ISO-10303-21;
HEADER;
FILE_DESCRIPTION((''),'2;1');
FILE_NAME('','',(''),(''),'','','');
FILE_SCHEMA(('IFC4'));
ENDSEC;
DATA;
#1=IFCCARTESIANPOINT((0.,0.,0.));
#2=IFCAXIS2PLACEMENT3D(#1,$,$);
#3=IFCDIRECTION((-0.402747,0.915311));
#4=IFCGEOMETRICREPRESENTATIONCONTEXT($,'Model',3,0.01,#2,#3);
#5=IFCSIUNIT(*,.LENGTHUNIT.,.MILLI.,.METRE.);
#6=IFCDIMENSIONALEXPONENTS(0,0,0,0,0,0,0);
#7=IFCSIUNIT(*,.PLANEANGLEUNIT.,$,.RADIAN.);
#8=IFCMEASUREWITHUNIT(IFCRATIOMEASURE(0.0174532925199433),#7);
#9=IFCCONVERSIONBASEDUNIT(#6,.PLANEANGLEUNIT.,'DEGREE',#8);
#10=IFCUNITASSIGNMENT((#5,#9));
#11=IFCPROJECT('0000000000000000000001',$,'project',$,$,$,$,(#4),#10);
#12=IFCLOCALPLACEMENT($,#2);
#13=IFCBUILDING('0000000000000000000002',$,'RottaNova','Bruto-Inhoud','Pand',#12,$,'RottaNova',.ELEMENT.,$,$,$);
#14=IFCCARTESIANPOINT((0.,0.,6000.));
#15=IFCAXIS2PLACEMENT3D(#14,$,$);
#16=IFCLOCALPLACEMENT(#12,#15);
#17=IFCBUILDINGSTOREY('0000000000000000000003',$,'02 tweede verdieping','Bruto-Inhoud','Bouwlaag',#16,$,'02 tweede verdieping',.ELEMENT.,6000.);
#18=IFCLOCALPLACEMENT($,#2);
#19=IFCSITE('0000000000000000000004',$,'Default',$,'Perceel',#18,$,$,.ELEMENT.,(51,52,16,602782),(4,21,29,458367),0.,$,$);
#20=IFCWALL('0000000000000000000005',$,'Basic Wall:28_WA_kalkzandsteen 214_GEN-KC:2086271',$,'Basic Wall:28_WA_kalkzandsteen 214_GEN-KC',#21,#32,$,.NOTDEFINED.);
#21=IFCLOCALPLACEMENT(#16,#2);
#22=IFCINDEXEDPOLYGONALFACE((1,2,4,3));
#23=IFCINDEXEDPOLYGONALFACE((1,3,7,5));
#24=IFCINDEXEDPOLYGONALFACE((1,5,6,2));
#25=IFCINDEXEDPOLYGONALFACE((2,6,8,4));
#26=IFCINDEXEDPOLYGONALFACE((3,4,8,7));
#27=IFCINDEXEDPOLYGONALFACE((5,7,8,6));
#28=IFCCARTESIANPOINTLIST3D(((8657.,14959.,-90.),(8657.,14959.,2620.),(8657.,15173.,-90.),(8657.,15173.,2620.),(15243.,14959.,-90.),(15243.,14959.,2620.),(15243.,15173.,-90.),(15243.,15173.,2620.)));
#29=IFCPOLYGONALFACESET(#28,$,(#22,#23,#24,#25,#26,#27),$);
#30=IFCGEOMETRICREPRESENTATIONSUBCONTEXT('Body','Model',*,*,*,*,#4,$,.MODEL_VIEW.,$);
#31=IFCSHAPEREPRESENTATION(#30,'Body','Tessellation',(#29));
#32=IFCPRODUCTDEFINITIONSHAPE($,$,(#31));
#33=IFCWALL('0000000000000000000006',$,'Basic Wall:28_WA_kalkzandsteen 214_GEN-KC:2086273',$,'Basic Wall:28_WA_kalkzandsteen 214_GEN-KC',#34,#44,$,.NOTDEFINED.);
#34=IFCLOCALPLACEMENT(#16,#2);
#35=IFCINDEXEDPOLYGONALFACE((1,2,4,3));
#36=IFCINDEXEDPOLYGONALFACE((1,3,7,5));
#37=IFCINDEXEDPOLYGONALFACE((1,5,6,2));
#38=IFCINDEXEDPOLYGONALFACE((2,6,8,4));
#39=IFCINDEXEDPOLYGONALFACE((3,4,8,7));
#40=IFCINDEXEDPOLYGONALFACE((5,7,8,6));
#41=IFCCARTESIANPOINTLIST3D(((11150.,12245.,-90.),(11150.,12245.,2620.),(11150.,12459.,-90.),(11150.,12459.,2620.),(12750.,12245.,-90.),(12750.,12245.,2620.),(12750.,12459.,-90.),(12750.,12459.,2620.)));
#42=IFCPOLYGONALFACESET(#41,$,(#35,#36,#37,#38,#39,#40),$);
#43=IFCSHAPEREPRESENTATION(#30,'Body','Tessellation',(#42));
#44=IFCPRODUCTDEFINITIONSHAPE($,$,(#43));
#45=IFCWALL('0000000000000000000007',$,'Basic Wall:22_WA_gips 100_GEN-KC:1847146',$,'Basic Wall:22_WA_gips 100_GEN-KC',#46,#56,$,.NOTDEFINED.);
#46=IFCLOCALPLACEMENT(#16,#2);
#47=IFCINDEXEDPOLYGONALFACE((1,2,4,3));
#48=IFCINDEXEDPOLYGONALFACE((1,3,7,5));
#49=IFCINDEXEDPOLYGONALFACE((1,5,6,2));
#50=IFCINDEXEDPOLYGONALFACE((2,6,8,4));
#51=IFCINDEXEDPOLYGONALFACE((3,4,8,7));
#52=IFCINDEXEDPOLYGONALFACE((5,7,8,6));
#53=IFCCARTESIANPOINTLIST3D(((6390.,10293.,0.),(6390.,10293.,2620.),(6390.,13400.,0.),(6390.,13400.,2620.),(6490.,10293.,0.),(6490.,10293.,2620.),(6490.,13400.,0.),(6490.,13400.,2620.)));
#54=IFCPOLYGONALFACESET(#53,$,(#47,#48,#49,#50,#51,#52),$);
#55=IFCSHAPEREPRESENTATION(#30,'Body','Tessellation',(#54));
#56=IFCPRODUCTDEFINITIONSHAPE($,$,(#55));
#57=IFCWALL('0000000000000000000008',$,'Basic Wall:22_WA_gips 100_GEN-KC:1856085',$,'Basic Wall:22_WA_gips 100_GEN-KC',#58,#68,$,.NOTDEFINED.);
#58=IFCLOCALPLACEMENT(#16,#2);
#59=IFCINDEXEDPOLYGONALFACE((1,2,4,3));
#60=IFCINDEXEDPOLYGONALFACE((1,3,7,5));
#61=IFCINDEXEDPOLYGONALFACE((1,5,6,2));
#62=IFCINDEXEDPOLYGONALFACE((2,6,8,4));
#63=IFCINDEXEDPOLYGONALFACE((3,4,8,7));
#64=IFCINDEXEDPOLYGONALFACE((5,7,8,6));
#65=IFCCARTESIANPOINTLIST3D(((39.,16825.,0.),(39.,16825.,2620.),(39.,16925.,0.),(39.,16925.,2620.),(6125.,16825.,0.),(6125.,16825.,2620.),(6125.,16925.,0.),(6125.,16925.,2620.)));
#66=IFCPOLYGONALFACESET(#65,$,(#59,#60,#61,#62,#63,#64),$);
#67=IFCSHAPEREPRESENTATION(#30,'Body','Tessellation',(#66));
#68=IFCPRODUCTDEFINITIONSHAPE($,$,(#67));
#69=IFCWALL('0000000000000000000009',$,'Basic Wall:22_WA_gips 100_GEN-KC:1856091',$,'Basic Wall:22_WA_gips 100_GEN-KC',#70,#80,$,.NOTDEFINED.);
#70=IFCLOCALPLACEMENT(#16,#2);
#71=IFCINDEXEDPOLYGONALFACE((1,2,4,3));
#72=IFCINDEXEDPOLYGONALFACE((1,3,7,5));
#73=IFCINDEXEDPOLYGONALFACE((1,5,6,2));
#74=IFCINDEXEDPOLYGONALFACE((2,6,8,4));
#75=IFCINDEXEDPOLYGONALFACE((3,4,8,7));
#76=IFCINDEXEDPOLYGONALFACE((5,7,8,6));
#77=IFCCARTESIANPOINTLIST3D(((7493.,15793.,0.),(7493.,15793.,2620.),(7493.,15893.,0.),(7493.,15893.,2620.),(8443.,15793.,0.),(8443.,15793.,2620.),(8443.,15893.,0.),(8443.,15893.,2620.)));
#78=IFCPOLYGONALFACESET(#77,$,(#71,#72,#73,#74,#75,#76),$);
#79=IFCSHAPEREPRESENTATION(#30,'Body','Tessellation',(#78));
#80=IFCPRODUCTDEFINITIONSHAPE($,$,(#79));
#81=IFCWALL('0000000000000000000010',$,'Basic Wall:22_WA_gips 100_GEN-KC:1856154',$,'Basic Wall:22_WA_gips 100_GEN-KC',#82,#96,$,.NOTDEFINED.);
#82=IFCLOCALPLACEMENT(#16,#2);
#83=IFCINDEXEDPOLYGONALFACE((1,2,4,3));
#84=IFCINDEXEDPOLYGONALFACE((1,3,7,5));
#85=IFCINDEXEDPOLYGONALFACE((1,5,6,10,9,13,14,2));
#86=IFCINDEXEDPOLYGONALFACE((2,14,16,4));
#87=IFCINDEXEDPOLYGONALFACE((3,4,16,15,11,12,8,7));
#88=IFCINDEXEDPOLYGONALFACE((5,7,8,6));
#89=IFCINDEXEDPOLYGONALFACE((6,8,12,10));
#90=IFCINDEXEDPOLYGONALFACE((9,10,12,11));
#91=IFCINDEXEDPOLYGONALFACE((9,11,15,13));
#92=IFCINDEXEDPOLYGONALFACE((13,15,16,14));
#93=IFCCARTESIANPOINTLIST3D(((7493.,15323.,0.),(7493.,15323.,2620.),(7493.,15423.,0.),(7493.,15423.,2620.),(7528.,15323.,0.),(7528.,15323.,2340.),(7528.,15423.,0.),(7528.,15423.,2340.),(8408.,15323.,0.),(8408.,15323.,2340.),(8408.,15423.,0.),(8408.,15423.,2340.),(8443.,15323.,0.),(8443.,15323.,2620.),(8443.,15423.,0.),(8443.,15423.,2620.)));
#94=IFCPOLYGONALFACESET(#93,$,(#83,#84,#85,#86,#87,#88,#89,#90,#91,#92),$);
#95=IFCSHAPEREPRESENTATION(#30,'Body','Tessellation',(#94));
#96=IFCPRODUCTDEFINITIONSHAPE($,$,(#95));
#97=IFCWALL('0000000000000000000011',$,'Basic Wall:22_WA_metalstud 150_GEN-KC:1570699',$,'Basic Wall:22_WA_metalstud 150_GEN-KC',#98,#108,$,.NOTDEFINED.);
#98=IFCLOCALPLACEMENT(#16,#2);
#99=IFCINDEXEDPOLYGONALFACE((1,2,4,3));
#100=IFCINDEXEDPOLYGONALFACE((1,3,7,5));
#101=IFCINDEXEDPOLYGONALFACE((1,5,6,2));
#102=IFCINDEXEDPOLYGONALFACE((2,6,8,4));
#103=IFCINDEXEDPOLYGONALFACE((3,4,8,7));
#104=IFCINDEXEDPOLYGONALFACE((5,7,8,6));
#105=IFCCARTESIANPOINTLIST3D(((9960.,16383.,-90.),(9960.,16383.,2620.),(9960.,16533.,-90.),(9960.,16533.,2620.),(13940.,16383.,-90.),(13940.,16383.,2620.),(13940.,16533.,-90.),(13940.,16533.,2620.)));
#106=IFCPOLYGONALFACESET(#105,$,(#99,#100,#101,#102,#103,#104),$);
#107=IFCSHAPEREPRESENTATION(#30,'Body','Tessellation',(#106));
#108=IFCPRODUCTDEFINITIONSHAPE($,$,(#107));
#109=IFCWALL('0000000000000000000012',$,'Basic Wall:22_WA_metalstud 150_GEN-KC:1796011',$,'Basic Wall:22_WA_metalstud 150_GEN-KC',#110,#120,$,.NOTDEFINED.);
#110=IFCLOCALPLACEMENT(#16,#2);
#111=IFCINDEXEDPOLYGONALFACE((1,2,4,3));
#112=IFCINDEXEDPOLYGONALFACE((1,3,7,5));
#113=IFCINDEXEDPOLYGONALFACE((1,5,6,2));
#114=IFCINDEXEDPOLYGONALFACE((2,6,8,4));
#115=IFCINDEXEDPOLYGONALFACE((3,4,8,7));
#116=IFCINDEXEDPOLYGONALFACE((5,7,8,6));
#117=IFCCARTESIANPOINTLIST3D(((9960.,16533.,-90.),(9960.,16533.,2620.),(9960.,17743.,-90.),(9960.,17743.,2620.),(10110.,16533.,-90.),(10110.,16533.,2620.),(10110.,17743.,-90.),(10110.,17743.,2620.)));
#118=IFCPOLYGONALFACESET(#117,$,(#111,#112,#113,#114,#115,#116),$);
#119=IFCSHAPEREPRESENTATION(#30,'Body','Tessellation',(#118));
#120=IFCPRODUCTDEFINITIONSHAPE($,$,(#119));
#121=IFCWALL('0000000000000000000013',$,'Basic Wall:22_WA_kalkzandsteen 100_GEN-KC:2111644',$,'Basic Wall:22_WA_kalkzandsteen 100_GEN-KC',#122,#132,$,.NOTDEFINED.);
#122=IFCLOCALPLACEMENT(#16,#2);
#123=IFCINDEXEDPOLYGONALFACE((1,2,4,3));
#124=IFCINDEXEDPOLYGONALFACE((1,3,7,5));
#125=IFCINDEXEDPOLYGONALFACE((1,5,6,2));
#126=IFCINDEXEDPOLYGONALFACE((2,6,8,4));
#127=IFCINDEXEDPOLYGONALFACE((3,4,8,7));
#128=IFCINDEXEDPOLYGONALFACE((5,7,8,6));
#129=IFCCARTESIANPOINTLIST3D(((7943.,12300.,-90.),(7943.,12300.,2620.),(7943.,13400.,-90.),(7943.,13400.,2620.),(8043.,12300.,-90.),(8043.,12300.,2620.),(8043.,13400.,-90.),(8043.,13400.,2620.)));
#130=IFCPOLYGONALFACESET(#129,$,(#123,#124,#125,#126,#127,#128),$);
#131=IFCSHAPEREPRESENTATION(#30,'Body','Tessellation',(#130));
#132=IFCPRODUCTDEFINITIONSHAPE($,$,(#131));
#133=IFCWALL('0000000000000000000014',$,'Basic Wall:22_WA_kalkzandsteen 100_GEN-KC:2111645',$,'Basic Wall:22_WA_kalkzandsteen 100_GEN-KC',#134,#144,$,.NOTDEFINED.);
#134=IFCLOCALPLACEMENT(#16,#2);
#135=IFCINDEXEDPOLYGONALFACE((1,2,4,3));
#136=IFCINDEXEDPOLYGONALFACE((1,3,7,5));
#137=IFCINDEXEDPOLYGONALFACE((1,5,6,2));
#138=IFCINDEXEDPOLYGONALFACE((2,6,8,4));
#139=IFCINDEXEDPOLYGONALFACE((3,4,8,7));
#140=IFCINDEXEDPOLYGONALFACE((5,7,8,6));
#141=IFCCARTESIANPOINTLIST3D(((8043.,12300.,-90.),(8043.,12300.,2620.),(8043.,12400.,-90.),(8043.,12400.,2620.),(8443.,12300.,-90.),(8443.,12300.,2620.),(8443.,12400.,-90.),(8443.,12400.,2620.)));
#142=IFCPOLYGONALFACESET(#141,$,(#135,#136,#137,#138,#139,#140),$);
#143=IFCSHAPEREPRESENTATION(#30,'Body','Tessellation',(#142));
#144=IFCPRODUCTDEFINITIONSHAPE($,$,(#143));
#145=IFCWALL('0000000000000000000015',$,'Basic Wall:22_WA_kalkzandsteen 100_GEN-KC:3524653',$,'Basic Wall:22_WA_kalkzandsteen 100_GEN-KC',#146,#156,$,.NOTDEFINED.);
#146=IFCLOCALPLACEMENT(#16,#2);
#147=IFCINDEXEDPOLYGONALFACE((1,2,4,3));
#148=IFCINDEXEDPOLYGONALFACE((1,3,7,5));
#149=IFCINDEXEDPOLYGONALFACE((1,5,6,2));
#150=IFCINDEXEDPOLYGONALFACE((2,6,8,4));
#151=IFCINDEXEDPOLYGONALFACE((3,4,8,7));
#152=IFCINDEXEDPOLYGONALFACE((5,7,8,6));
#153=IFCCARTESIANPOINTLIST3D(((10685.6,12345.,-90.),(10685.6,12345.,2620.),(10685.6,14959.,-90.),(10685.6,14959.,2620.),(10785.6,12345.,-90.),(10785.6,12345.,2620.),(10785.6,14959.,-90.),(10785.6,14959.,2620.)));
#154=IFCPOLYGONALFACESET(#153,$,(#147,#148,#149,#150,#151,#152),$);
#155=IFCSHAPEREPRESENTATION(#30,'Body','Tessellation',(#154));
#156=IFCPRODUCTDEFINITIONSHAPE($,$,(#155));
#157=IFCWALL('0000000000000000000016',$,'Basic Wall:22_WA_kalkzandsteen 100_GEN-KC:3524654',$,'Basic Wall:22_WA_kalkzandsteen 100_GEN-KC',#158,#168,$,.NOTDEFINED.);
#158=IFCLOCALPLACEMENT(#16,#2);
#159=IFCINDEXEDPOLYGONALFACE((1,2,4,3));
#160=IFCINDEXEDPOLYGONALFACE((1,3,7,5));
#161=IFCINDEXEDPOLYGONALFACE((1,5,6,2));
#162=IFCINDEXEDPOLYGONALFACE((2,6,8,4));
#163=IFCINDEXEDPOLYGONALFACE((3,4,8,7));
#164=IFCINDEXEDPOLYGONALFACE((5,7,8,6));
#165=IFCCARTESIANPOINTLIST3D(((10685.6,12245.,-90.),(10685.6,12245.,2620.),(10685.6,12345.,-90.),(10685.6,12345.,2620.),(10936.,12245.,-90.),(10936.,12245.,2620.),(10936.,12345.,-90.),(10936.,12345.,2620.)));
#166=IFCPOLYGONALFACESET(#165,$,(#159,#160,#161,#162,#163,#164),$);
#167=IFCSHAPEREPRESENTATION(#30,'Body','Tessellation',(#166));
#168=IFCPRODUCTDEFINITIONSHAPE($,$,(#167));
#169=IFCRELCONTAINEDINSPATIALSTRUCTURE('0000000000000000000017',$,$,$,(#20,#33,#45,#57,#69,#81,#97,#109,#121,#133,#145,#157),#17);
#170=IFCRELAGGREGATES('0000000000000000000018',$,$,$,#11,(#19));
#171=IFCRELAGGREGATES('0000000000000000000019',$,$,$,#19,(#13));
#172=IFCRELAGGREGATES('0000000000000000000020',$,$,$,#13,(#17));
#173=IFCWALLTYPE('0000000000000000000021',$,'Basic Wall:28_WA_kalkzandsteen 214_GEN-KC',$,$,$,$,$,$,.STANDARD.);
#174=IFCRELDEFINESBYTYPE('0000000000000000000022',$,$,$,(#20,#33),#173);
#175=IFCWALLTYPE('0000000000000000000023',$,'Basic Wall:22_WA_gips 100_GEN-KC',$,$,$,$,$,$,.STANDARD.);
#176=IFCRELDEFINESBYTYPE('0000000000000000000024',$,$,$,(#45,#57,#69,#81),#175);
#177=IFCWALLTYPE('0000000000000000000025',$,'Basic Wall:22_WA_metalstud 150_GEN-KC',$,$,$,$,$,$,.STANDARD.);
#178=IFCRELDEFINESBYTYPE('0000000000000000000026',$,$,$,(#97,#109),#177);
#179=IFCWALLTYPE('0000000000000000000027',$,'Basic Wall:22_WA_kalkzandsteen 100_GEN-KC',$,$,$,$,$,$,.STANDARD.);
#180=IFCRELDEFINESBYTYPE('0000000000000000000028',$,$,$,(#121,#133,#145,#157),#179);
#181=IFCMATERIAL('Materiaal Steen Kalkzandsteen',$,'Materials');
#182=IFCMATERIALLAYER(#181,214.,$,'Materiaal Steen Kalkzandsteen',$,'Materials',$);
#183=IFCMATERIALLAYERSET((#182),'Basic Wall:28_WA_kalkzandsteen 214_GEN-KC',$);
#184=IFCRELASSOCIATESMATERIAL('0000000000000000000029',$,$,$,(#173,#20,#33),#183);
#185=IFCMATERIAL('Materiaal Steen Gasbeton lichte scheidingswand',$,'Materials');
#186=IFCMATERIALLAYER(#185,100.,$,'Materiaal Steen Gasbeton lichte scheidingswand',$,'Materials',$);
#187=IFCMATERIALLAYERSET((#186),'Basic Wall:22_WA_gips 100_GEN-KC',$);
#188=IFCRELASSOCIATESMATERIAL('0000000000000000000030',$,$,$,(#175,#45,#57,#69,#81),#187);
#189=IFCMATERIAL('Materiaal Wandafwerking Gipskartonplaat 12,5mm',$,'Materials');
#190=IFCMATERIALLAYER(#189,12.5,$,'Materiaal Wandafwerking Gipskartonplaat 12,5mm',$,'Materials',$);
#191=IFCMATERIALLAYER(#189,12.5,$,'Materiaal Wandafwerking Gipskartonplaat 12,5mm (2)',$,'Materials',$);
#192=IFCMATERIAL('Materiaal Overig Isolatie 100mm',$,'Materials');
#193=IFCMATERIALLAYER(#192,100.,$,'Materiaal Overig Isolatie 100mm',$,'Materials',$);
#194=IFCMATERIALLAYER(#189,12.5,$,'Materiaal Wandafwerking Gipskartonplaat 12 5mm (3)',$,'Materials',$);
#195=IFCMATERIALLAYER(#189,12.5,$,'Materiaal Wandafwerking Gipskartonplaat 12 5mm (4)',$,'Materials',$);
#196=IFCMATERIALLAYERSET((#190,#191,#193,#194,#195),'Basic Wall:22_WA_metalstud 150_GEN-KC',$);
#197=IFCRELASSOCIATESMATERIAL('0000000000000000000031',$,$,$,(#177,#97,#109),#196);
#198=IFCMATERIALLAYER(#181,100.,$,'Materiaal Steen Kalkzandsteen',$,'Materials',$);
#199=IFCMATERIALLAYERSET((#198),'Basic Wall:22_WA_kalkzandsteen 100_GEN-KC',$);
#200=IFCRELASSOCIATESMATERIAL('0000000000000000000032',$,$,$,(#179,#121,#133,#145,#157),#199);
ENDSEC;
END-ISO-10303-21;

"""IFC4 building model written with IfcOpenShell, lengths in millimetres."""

from ifc_helpers import new_model, entity, si_unit, converted_unit, direction, frame, frame_2d, origin, place, context, subcontext, project, spatial, rectangle, extrude, material, layer, layer_set, type_object, element, save


model = new_model("IFC4")

# Units and contexts
model_context = context("Model", 3, precision=0.01, world=origin(), true_north=direction((-0.402747, 0.915311)))
body_context = subcontext(model_context, "Body", "Model", "MODEL_VIEW")
ifc_project = project(units=[si_unit("LENGTHUNIT", "METRE", prefix="MILLI"), converted_unit("PLANEANGLEUNIT", "DEGREE", entity("IfcRatioMeasure", 0.0174532925199433), si_unit("PLANEANGLEUNIT", "RADIAN"), dimensions=[0, 0, 0, 0, 0, 0, 0])], contexts=[model_context])

# Site, building, storey
site_placement = place(None, origin())
site = spatial("IfcSite", under=ifc_project, at=site_placement, Name="Default", ObjectType="Perceel", CompositionType="ELEMENT", RefLatitude=(51, 52, 16, 602782), RefLongitude=(4, 21, 29, 458367), RefElevation=0.0)
building_placement = place(None, origin())
building = spatial("IfcBuilding", under=site, at=building_placement, Name="RottaNova", Description="Bruto-Inhoud", ObjectType="Pand", LongName="RottaNova", CompositionType="ELEMENT")
storey_placement = place(building_placement, frame((0.0, 0.0, 6000.0)))
storey = spatial("IfcBuildingStorey", under=building, at=storey_placement, Name="02 tweede verdieping", Description="Bruto-Inhoud", ObjectType="Bouwlaag", LongName="02 tweede verdieping", CompositionType="ELEMENT", Elevation=6000.0)

# Walls
ifc_material_1 = material(Name="Materiaal Steen Kalkzandsteen", Category="Materials")
ifc_layer_1 = layer(ifc_material_1, 214.0, Name="Materiaal Steen Kalkzandsteen", Category="Materials")
ifc_layer_set_1 = layer_set([ifc_layer_1], Name="Basic Wall:28_WA_kalkzandsteen 214_GEN-KC")
wall_type_1 = type_object("IfcWallType", Name="Basic Wall:28_WA_kalkzandsteen 214_GEN-KC", PredefinedType="STANDARD", material=ifc_layer_set_1)
wall_1_placement = place(storey_placement, frame((8657.0, 15066.0, -90.0)))
element("IfcWall", 1, at=wall_1_placement, inside=storey, type_object=wall_type_1, material=ifc_layer_set_1, Name="Basic Wall:28_WA_kalkzandsteen 214_GEN-KC:2086271", ObjectType="Basic Wall:28_WA_kalkzandsteen 214_GEN-KC", PredefinedType="NOTDEFINED", context=body_context, shape_type="SweptSolid", body=[
    extrude(rectangle(XDim=6586.0, YDim=214.0, at=frame_2d((3293.0, 0.0), x_axis=(1.0, 0.0))), origin(), (0.0, 0.0, 1.0), 2710.0),
])
wall_2_placement = place(storey_placement, frame((11150.0, 12352.0, -90.0)))
element("IfcWall", 2, at=wall_2_placement, inside=storey, type_object=wall_type_1, material=ifc_layer_set_1, Name="Basic Wall:28_WA_kalkzandsteen 214_GEN-KC:2086273", ObjectType="Basic Wall:28_WA_kalkzandsteen 214_GEN-KC", PredefinedType="NOTDEFINED", context=body_context, shape_type="SweptSolid", body=[
    extrude(rectangle(XDim=1600.0, YDim=214.0, at=frame_2d((800.0, 0.0), x_axis=(-1.0, 0.0))), origin(), (0.0, 0.0, 1.0), 2710.0),
])
ifc_material_2 = material(Name="Materiaal Steen Gasbeton lichte scheidingswand", Category="Materials")
ifc_layer_2 = layer(ifc_material_2, 100.0, Name="Materiaal Steen Gasbeton lichte scheidingswand", Category="Materials")
ifc_layer_set_2 = layer_set([ifc_layer_2], Name="Basic Wall:22_WA_gips 100_GEN-KC")
wall_type_2 = type_object("IfcWallType", Name="Basic Wall:22_WA_gips 100_GEN-KC", PredefinedType="STANDARD", material=ifc_layer_set_2)
wall_3_placement = place(storey_placement, frame((6440.0, 13400.0, 0.0), z_axis=(0.0, 0.0, 1.0), x_axis=(0.0, -1.0, 0.0)))
element("IfcWall", 3, at=wall_3_placement, inside=storey, type_object=wall_type_2, material=ifc_layer_set_2, Name="Basic Wall:22_WA_gips 100_GEN-KC:1847146", ObjectType="Basic Wall:22_WA_gips 100_GEN-KC", PredefinedType="NOTDEFINED", context=body_context, shape_type="SweptSolid", body=[
    extrude(rectangle(XDim=3107.0, YDim=100.0, at=frame_2d((1553.5, 0.0), x_axis=(-1.0, 0.0))), origin(), (0.0, 0.0, 1.0), 2620.0),
])
wall_4_placement = place(storey_placement, frame((39.0, 16875.0, 0.0)))
element("IfcWall", 4, at=wall_4_placement, inside=storey, type_object=wall_type_2, material=ifc_layer_set_2, Name="Basic Wall:22_WA_gips 100_GEN-KC:1856085", ObjectType="Basic Wall:22_WA_gips 100_GEN-KC", PredefinedType="NOTDEFINED", context=body_context, shape_type="SweptSolid", body=[
    extrude(rectangle(XDim=6086.0, YDim=100.0, at=frame_2d((3043.0, 0.0), x_axis=(-1.0, 0.0))), origin(), (0.0, 0.0, 1.0), 2620.0),
])
wall_5_placement = place(storey_placement, frame((7493.0, 15843.0, 0.0)))
element("IfcWall", 5, at=wall_5_placement, inside=storey, type_object=wall_type_2, material=ifc_layer_set_2, Name="Basic Wall:22_WA_gips 100_GEN-KC:1856091", ObjectType="Basic Wall:22_WA_gips 100_GEN-KC", PredefinedType="NOTDEFINED", context=body_context, shape_type="SweptSolid", body=[
    extrude(rectangle(XDim=950.0, YDim=100.0, at=frame_2d((475.0, 0.0), x_axis=(-1.0, 0.0))), origin(), (0.0, 0.0, 1.0), 2620.0),
])

# Wall, opening
wall_6_placement = place(storey_placement, frame((7493.0, 15373.0, 0.0)))
wall_6 = element("IfcWall", 6, at=wall_6_placement, inside=storey, type_object=wall_type_2, material=ifc_layer_set_2, Name="Basic Wall:22_WA_gips 100_GEN-KC:1856154", ObjectType="Basic Wall:22_WA_gips 100_GEN-KC", PredefinedType="NOTDEFINED", context=body_context, shape_type="SweptSolid", body=[
    extrude(rectangle(XDim=950.0, YDim=100.0, at=frame_2d((475.0, 0.0), x_axis=(-1.0, 0.0))), origin(), (0.0, 0.0, 1.0), 2620.0),
])
opening_placement = place(wall_6_placement, frame((915.0, 50.0, -70.0)))
element("IfcOpeningElement", 7, at=opening_placement, cuts=wall_6, PredefinedType="OPENING", context=body_context, shape_type="SweptSolid", body=[
    extrude(rectangle(XDim=2410.0, YDim=880.0, at=frame_2d((1205.0, 440.0), x_axis=(1.0, 0.0))), frame((0.0, 0.0, 0.0), z_axis=(0.0, -1.0, 0.0), x_axis=(0.0, 0.0, 1.0)), (0.0, 0.0, 1.0), 100.0),
])

# Walls
ifc_material_3 = material(Name="Materiaal Wandafwerking Gipskartonplaat 12,5mm", Category="Materials")
ifc_layer_3 = layer(ifc_material_3, 12.5, Name="Materiaal Wandafwerking Gipskartonplaat 12,5mm", Category="Materials")
ifc_layer_4 = layer(ifc_material_3, 12.5, Name="Materiaal Wandafwerking Gipskartonplaat 12,5mm (2)", Category="Materials")
ifc_material_4 = material(Name="Materiaal Overig Isolatie 100mm", Category="Materials")
ifc_layer_5 = layer(ifc_material_4, 100.0, Name="Materiaal Overig Isolatie 100mm", Category="Materials")
ifc_layer_6 = layer(ifc_material_3, 12.5, Name="Materiaal Wandafwerking Gipskartonplaat 12 5mm (3)", Category="Materials")
ifc_layer_7 = layer(ifc_material_3, 12.5, Name="Materiaal Wandafwerking Gipskartonplaat 12 5mm (4)", Category="Materials")
ifc_layer_set_3 = layer_set([ifc_layer_3, ifc_layer_4, ifc_layer_5, ifc_layer_6, ifc_layer_7], Name="Basic Wall:22_WA_metalstud 150_GEN-KC")
wall_type_3 = type_object("IfcWallType", Name="Basic Wall:22_WA_metalstud 150_GEN-KC", PredefinedType="STANDARD", material=ifc_layer_set_3)
wall_7_placement = place(storey_placement, frame((9960.0, 16458.0, -90.0)))
element("IfcWall", 8, at=wall_7_placement, inside=storey, type_object=wall_type_3, material=ifc_layer_set_3, Name="Basic Wall:22_WA_metalstud 150_GEN-KC:1570699", ObjectType="Basic Wall:22_WA_metalstud 150_GEN-KC", PredefinedType="NOTDEFINED", context=body_context, shape_type="SweptSolid", body=[
    extrude(rectangle(XDim=3980.0, YDim=150.0, at=frame_2d((1990.0, 0.0), x_axis=(-1.0, 0.0))), origin(), (0.0, 0.0, 1.0), 2710.0),
])
wall_8_placement = place(storey_placement, frame((10035.0, 16533.0, -90.0), z_axis=(0.0, 0.0, 1.0), x_axis=(0.0, 1.0, 0.0)))
element("IfcWall", 9, at=wall_8_placement, inside=storey, type_object=wall_type_3, material=ifc_layer_set_3, Name="Basic Wall:22_WA_metalstud 150_GEN-KC:1796011", ObjectType="Basic Wall:22_WA_metalstud 150_GEN-KC", PredefinedType="NOTDEFINED", context=body_context, shape_type="SweptSolid", body=[
    extrude(rectangle(XDim=1210.0, YDim=150.0, at=frame_2d((605.0, 0.0), x_axis=(-1.0, 0.0))), origin(), (0.0, 0.0, 1.0), 2710.0),
])
ifc_layer_8 = layer(ifc_material_1, 100.0, Name="Materiaal Steen Kalkzandsteen", Category="Materials")
ifc_layer_set_4 = layer_set([ifc_layer_8], Name="Basic Wall:22_WA_kalkzandsteen 100_GEN-KC")
wall_type_4 = type_object("IfcWallType", Name="Basic Wall:22_WA_kalkzandsteen 100_GEN-KC", PredefinedType="STANDARD", material=ifc_layer_set_4)
wall_9_placement = place(storey_placement, frame((7993.0, 13400.0, -90.0), z_axis=(0.0, 0.0, 1.0), x_axis=(0.0, -1.0, 0.0)))
element("IfcWall", 10, at=wall_9_placement, inside=storey, type_object=wall_type_4, material=ifc_layer_set_4, Name="Basic Wall:22_WA_kalkzandsteen 100_GEN-KC:2111644", ObjectType="Basic Wall:22_WA_kalkzandsteen 100_GEN-KC", PredefinedType="NOTDEFINED", context=body_context, shape_type="SweptSolid", body=[
    extrude(rectangle(XDim=1100.0, YDim=100.0, at=frame_2d((550.0, 0.0), x_axis=(-1.0, 0.0))), origin(), (0.0, 0.0, 1.0), 2710.0),
])
wall_10_placement = place(storey_placement, frame((8043.0, 12350.0, -90.0)))
element("IfcWall", 11, at=wall_10_placement, inside=storey, type_object=wall_type_4, material=ifc_layer_set_4, Name="Basic Wall:22_WA_kalkzandsteen 100_GEN-KC:2111645", ObjectType="Basic Wall:22_WA_kalkzandsteen 100_GEN-KC", PredefinedType="NOTDEFINED", context=body_context, shape_type="SweptSolid", body=[
    extrude(rectangle(XDim=400.0, YDim=100.0, at=frame_2d((200.0, 0.0), x_axis=(-1.0, 0.0))), origin(), (0.0, 0.0, 1.0), 2710.0),
])
wall_11_placement = place(storey_placement, frame((10735.6, 14959.0, -90.0), z_axis=(0.0, 0.0, 1.0), x_axis=(0.0, -1.0, 0.0)))
element("IfcWall", 12, at=wall_11_placement, inside=storey, type_object=wall_type_4, material=ifc_layer_set_4, Name="Basic Wall:22_WA_kalkzandsteen 100_GEN-KC:3524653", ObjectType="Basic Wall:22_WA_kalkzandsteen 100_GEN-KC", PredefinedType="NOTDEFINED", context=body_context, shape_type="SweptSolid", body=[
    extrude(rectangle(XDim=2614.0, YDim=100.0, at=frame_2d((1307.0, 0.0), x_axis=(-1.0, 0.0))), origin(), (0.0, 0.0, 1.0), 2710.0),
])
wall_12_placement = place(storey_placement, frame((10685.6, 12295.0, -90.0)))
element("IfcWall", 13, at=wall_12_placement, inside=storey, type_object=wall_type_4, material=ifc_layer_set_4, Name="Basic Wall:22_WA_kalkzandsteen 100_GEN-KC:3524654", ObjectType="Basic Wall:22_WA_kalkzandsteen 100_GEN-KC", PredefinedType="NOTDEFINED", context=body_context, shape_type="SweptSolid", body=[
    extrude(rectangle(XDim=250.4, YDim=100.0, at=frame_2d((125.2, 0.0), x_axis=(-1.0, 0.0))), origin(), (0.0, 0.0, 1.0), 2710.0),
])

save(model, "model.ifc")
